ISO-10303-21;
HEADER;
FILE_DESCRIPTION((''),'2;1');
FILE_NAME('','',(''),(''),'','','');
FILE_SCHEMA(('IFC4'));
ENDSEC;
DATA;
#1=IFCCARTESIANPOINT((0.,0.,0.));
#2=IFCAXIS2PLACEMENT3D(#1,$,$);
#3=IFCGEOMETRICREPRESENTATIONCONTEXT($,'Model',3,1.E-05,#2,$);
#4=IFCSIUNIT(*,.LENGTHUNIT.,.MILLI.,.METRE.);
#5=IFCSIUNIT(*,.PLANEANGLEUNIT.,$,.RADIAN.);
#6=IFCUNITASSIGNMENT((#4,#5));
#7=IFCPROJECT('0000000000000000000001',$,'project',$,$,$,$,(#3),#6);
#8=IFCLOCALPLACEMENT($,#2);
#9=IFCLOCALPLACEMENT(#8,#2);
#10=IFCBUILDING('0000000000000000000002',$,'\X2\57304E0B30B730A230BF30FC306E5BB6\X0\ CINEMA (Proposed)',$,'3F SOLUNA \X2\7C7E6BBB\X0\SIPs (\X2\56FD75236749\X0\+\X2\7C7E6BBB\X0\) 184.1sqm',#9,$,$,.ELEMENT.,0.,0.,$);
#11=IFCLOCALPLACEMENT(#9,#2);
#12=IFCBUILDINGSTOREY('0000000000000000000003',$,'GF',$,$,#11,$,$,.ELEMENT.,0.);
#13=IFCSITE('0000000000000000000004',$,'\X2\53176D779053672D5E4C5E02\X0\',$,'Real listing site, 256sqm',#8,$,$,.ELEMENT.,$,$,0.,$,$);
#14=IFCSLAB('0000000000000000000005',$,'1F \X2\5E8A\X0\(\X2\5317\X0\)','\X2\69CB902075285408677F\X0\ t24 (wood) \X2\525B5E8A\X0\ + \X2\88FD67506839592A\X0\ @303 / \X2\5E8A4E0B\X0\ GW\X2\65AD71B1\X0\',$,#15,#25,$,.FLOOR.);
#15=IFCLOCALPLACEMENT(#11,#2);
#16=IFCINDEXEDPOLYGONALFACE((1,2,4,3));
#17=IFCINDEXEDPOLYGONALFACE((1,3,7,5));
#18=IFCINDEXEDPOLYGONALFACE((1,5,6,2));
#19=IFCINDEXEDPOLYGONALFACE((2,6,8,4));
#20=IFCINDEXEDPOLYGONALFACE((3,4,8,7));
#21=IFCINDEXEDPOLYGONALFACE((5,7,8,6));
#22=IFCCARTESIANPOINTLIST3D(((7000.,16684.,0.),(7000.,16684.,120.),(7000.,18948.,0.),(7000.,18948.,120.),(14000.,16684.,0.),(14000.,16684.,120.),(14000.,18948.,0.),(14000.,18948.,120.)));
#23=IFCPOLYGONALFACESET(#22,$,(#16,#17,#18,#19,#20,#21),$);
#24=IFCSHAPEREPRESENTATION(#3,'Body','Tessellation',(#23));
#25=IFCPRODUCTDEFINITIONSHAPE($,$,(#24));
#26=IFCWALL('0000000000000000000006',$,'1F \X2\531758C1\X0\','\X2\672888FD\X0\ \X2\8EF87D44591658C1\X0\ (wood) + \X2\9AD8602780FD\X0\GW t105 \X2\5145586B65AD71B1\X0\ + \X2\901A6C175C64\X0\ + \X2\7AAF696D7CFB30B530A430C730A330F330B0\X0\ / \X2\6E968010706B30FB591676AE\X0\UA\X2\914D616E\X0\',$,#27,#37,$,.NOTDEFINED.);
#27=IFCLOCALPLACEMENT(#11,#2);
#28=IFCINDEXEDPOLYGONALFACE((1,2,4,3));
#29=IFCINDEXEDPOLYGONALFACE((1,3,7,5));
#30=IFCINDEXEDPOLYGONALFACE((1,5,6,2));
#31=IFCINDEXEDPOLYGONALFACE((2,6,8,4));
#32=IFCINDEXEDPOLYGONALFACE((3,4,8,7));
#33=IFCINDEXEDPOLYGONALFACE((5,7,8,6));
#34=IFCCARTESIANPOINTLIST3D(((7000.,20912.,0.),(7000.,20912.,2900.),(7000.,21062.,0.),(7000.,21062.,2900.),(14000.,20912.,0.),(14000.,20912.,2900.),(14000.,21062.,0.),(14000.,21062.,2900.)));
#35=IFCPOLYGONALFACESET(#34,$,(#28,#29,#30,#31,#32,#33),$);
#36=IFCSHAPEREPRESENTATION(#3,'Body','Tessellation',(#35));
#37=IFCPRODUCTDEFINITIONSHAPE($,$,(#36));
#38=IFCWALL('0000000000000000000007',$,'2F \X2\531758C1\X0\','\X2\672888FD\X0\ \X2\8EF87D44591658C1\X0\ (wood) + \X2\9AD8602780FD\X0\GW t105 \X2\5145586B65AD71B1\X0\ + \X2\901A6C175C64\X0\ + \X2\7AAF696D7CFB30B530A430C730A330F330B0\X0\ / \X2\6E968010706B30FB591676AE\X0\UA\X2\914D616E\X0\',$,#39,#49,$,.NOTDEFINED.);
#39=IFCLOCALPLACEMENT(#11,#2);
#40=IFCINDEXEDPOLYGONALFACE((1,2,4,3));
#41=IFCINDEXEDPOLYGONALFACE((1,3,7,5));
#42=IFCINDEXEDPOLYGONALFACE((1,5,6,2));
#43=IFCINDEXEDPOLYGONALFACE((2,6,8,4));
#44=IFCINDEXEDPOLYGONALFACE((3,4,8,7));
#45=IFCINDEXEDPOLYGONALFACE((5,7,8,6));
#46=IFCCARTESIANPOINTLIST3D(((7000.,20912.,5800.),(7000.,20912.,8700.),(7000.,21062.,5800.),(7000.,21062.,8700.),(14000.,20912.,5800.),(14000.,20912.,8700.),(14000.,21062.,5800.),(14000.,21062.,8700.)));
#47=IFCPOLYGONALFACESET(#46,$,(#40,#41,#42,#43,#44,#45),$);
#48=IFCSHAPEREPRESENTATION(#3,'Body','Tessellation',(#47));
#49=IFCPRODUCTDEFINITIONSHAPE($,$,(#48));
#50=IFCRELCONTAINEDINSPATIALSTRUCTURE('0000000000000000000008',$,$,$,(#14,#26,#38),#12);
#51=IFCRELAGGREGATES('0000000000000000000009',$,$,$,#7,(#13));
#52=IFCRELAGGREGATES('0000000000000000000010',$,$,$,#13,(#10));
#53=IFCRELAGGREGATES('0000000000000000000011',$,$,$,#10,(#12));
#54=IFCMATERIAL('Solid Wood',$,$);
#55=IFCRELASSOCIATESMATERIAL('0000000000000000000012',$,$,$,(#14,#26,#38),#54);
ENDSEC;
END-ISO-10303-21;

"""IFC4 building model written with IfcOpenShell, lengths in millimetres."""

from ifc_helpers import new_model, si_unit, frame, frame_2d, origin, place, context, project, spatial, rectangle, extrude, material, element, save


model = new_model("IFC4")

# Units and contexts
model_context = context("Model", 3, precision=1e-05, world=origin())
ifc_project = project(units=[si_unit("LENGTHUNIT", "METRE", prefix="MILLI"), si_unit("PLANEANGLEUNIT", "RADIAN")], contexts=[model_context])

# Site, building, storey
site_placement = place(None, origin())
site = spatial("IfcSite", under=ifc_project, at=site_placement, Name="北海道札幌市", ObjectType="Real listing site, 256sqm", CompositionType="ELEMENT", RefElevation=0.0)
building_placement = place(site_placement, origin())
building = spatial("IfcBuilding", under=site, at=building_placement, Name="地下シアターの家 CINEMA (Proposed)", ObjectType="3F SOLUNA 籾殻SIPs (国産杉+籾殻) 184.1sqm", CompositionType="ELEMENT", ElevationOfRefHeight=0.0, ElevationOfTerrain=0.0)
storey_placement = place(building_placement, origin())
storey = spatial("IfcBuildingStorey", under=building, at=storey_placement, Name="GF", CompositionType="ELEMENT", Elevation=0.0)

# Slab
ifc_material_1 = material(Name="Solid Wood")
slab_1_placement = place(storey_placement, frame((3500.0, 8342.0, 0.0)))
element("IfcSlab", 1, at=slab_1_placement, inside=storey, material=ifc_material_1, Name="1F 床(北)", Description="構造用合板 t24 (wood) 剛床 + 製材根太 @303 / 床下 GW断熱", PredefinedType="FLOOR", context=model_context, shape_type="SweptSolid", body=[
    extrude(rectangle(XDim=7000.0, YDim=2264.0, at=frame_2d((3500.0, 1132.0))), frame((3500.0, 8342.0, 0.0)), (0.0, 0.0, 1.0), 120.0),
])

# Wall
wall_1_placement = place(storey_placement, frame((3500.0, 10456.0, 0.0)))
element("IfcWall", 2, at=wall_1_placement, inside=storey, material=ifc_material_1, Name="1F 北壁", Description="木製 軸組外壁 (wood) + 高性能GW t105 充填断熱 + 通気層 + 窯業系サイディング / 準耐火・外皮UA配慮", PredefinedType="NOTDEFINED", context=model_context, shape_type="SweptSolid", body=[
    extrude(rectangle(XDim=7000.0, YDim=150.0, at=frame_2d((3500.0, 75.0))), frame((3500.0, 10456.0, 0.0)), (0.0, 0.0, 1.0), 2900.0),
])

# Wall
wall_2_placement = place(storey_placement, frame((3500.0, 10456.0, 2900.0)))
element("IfcWall", 3, at=wall_2_placement, inside=storey, material=ifc_material_1, Name="2F 北壁", Description="木製 軸組外壁 (wood) + 高性能GW t105 充填断熱 + 通気層 + 窯業系サイディング / 準耐火・外皮UA配慮", PredefinedType="NOTDEFINED", context=model_context, shape_type="SweptSolid", body=[
    extrude(rectangle(XDim=7000.0, YDim=150.0, at=frame_2d((3500.0, 75.0))), frame((3500.0, 10456.0, 2900.0)), (0.0, 0.0, 1.0), 2900.0),
])

save(model, "model.ifc")
